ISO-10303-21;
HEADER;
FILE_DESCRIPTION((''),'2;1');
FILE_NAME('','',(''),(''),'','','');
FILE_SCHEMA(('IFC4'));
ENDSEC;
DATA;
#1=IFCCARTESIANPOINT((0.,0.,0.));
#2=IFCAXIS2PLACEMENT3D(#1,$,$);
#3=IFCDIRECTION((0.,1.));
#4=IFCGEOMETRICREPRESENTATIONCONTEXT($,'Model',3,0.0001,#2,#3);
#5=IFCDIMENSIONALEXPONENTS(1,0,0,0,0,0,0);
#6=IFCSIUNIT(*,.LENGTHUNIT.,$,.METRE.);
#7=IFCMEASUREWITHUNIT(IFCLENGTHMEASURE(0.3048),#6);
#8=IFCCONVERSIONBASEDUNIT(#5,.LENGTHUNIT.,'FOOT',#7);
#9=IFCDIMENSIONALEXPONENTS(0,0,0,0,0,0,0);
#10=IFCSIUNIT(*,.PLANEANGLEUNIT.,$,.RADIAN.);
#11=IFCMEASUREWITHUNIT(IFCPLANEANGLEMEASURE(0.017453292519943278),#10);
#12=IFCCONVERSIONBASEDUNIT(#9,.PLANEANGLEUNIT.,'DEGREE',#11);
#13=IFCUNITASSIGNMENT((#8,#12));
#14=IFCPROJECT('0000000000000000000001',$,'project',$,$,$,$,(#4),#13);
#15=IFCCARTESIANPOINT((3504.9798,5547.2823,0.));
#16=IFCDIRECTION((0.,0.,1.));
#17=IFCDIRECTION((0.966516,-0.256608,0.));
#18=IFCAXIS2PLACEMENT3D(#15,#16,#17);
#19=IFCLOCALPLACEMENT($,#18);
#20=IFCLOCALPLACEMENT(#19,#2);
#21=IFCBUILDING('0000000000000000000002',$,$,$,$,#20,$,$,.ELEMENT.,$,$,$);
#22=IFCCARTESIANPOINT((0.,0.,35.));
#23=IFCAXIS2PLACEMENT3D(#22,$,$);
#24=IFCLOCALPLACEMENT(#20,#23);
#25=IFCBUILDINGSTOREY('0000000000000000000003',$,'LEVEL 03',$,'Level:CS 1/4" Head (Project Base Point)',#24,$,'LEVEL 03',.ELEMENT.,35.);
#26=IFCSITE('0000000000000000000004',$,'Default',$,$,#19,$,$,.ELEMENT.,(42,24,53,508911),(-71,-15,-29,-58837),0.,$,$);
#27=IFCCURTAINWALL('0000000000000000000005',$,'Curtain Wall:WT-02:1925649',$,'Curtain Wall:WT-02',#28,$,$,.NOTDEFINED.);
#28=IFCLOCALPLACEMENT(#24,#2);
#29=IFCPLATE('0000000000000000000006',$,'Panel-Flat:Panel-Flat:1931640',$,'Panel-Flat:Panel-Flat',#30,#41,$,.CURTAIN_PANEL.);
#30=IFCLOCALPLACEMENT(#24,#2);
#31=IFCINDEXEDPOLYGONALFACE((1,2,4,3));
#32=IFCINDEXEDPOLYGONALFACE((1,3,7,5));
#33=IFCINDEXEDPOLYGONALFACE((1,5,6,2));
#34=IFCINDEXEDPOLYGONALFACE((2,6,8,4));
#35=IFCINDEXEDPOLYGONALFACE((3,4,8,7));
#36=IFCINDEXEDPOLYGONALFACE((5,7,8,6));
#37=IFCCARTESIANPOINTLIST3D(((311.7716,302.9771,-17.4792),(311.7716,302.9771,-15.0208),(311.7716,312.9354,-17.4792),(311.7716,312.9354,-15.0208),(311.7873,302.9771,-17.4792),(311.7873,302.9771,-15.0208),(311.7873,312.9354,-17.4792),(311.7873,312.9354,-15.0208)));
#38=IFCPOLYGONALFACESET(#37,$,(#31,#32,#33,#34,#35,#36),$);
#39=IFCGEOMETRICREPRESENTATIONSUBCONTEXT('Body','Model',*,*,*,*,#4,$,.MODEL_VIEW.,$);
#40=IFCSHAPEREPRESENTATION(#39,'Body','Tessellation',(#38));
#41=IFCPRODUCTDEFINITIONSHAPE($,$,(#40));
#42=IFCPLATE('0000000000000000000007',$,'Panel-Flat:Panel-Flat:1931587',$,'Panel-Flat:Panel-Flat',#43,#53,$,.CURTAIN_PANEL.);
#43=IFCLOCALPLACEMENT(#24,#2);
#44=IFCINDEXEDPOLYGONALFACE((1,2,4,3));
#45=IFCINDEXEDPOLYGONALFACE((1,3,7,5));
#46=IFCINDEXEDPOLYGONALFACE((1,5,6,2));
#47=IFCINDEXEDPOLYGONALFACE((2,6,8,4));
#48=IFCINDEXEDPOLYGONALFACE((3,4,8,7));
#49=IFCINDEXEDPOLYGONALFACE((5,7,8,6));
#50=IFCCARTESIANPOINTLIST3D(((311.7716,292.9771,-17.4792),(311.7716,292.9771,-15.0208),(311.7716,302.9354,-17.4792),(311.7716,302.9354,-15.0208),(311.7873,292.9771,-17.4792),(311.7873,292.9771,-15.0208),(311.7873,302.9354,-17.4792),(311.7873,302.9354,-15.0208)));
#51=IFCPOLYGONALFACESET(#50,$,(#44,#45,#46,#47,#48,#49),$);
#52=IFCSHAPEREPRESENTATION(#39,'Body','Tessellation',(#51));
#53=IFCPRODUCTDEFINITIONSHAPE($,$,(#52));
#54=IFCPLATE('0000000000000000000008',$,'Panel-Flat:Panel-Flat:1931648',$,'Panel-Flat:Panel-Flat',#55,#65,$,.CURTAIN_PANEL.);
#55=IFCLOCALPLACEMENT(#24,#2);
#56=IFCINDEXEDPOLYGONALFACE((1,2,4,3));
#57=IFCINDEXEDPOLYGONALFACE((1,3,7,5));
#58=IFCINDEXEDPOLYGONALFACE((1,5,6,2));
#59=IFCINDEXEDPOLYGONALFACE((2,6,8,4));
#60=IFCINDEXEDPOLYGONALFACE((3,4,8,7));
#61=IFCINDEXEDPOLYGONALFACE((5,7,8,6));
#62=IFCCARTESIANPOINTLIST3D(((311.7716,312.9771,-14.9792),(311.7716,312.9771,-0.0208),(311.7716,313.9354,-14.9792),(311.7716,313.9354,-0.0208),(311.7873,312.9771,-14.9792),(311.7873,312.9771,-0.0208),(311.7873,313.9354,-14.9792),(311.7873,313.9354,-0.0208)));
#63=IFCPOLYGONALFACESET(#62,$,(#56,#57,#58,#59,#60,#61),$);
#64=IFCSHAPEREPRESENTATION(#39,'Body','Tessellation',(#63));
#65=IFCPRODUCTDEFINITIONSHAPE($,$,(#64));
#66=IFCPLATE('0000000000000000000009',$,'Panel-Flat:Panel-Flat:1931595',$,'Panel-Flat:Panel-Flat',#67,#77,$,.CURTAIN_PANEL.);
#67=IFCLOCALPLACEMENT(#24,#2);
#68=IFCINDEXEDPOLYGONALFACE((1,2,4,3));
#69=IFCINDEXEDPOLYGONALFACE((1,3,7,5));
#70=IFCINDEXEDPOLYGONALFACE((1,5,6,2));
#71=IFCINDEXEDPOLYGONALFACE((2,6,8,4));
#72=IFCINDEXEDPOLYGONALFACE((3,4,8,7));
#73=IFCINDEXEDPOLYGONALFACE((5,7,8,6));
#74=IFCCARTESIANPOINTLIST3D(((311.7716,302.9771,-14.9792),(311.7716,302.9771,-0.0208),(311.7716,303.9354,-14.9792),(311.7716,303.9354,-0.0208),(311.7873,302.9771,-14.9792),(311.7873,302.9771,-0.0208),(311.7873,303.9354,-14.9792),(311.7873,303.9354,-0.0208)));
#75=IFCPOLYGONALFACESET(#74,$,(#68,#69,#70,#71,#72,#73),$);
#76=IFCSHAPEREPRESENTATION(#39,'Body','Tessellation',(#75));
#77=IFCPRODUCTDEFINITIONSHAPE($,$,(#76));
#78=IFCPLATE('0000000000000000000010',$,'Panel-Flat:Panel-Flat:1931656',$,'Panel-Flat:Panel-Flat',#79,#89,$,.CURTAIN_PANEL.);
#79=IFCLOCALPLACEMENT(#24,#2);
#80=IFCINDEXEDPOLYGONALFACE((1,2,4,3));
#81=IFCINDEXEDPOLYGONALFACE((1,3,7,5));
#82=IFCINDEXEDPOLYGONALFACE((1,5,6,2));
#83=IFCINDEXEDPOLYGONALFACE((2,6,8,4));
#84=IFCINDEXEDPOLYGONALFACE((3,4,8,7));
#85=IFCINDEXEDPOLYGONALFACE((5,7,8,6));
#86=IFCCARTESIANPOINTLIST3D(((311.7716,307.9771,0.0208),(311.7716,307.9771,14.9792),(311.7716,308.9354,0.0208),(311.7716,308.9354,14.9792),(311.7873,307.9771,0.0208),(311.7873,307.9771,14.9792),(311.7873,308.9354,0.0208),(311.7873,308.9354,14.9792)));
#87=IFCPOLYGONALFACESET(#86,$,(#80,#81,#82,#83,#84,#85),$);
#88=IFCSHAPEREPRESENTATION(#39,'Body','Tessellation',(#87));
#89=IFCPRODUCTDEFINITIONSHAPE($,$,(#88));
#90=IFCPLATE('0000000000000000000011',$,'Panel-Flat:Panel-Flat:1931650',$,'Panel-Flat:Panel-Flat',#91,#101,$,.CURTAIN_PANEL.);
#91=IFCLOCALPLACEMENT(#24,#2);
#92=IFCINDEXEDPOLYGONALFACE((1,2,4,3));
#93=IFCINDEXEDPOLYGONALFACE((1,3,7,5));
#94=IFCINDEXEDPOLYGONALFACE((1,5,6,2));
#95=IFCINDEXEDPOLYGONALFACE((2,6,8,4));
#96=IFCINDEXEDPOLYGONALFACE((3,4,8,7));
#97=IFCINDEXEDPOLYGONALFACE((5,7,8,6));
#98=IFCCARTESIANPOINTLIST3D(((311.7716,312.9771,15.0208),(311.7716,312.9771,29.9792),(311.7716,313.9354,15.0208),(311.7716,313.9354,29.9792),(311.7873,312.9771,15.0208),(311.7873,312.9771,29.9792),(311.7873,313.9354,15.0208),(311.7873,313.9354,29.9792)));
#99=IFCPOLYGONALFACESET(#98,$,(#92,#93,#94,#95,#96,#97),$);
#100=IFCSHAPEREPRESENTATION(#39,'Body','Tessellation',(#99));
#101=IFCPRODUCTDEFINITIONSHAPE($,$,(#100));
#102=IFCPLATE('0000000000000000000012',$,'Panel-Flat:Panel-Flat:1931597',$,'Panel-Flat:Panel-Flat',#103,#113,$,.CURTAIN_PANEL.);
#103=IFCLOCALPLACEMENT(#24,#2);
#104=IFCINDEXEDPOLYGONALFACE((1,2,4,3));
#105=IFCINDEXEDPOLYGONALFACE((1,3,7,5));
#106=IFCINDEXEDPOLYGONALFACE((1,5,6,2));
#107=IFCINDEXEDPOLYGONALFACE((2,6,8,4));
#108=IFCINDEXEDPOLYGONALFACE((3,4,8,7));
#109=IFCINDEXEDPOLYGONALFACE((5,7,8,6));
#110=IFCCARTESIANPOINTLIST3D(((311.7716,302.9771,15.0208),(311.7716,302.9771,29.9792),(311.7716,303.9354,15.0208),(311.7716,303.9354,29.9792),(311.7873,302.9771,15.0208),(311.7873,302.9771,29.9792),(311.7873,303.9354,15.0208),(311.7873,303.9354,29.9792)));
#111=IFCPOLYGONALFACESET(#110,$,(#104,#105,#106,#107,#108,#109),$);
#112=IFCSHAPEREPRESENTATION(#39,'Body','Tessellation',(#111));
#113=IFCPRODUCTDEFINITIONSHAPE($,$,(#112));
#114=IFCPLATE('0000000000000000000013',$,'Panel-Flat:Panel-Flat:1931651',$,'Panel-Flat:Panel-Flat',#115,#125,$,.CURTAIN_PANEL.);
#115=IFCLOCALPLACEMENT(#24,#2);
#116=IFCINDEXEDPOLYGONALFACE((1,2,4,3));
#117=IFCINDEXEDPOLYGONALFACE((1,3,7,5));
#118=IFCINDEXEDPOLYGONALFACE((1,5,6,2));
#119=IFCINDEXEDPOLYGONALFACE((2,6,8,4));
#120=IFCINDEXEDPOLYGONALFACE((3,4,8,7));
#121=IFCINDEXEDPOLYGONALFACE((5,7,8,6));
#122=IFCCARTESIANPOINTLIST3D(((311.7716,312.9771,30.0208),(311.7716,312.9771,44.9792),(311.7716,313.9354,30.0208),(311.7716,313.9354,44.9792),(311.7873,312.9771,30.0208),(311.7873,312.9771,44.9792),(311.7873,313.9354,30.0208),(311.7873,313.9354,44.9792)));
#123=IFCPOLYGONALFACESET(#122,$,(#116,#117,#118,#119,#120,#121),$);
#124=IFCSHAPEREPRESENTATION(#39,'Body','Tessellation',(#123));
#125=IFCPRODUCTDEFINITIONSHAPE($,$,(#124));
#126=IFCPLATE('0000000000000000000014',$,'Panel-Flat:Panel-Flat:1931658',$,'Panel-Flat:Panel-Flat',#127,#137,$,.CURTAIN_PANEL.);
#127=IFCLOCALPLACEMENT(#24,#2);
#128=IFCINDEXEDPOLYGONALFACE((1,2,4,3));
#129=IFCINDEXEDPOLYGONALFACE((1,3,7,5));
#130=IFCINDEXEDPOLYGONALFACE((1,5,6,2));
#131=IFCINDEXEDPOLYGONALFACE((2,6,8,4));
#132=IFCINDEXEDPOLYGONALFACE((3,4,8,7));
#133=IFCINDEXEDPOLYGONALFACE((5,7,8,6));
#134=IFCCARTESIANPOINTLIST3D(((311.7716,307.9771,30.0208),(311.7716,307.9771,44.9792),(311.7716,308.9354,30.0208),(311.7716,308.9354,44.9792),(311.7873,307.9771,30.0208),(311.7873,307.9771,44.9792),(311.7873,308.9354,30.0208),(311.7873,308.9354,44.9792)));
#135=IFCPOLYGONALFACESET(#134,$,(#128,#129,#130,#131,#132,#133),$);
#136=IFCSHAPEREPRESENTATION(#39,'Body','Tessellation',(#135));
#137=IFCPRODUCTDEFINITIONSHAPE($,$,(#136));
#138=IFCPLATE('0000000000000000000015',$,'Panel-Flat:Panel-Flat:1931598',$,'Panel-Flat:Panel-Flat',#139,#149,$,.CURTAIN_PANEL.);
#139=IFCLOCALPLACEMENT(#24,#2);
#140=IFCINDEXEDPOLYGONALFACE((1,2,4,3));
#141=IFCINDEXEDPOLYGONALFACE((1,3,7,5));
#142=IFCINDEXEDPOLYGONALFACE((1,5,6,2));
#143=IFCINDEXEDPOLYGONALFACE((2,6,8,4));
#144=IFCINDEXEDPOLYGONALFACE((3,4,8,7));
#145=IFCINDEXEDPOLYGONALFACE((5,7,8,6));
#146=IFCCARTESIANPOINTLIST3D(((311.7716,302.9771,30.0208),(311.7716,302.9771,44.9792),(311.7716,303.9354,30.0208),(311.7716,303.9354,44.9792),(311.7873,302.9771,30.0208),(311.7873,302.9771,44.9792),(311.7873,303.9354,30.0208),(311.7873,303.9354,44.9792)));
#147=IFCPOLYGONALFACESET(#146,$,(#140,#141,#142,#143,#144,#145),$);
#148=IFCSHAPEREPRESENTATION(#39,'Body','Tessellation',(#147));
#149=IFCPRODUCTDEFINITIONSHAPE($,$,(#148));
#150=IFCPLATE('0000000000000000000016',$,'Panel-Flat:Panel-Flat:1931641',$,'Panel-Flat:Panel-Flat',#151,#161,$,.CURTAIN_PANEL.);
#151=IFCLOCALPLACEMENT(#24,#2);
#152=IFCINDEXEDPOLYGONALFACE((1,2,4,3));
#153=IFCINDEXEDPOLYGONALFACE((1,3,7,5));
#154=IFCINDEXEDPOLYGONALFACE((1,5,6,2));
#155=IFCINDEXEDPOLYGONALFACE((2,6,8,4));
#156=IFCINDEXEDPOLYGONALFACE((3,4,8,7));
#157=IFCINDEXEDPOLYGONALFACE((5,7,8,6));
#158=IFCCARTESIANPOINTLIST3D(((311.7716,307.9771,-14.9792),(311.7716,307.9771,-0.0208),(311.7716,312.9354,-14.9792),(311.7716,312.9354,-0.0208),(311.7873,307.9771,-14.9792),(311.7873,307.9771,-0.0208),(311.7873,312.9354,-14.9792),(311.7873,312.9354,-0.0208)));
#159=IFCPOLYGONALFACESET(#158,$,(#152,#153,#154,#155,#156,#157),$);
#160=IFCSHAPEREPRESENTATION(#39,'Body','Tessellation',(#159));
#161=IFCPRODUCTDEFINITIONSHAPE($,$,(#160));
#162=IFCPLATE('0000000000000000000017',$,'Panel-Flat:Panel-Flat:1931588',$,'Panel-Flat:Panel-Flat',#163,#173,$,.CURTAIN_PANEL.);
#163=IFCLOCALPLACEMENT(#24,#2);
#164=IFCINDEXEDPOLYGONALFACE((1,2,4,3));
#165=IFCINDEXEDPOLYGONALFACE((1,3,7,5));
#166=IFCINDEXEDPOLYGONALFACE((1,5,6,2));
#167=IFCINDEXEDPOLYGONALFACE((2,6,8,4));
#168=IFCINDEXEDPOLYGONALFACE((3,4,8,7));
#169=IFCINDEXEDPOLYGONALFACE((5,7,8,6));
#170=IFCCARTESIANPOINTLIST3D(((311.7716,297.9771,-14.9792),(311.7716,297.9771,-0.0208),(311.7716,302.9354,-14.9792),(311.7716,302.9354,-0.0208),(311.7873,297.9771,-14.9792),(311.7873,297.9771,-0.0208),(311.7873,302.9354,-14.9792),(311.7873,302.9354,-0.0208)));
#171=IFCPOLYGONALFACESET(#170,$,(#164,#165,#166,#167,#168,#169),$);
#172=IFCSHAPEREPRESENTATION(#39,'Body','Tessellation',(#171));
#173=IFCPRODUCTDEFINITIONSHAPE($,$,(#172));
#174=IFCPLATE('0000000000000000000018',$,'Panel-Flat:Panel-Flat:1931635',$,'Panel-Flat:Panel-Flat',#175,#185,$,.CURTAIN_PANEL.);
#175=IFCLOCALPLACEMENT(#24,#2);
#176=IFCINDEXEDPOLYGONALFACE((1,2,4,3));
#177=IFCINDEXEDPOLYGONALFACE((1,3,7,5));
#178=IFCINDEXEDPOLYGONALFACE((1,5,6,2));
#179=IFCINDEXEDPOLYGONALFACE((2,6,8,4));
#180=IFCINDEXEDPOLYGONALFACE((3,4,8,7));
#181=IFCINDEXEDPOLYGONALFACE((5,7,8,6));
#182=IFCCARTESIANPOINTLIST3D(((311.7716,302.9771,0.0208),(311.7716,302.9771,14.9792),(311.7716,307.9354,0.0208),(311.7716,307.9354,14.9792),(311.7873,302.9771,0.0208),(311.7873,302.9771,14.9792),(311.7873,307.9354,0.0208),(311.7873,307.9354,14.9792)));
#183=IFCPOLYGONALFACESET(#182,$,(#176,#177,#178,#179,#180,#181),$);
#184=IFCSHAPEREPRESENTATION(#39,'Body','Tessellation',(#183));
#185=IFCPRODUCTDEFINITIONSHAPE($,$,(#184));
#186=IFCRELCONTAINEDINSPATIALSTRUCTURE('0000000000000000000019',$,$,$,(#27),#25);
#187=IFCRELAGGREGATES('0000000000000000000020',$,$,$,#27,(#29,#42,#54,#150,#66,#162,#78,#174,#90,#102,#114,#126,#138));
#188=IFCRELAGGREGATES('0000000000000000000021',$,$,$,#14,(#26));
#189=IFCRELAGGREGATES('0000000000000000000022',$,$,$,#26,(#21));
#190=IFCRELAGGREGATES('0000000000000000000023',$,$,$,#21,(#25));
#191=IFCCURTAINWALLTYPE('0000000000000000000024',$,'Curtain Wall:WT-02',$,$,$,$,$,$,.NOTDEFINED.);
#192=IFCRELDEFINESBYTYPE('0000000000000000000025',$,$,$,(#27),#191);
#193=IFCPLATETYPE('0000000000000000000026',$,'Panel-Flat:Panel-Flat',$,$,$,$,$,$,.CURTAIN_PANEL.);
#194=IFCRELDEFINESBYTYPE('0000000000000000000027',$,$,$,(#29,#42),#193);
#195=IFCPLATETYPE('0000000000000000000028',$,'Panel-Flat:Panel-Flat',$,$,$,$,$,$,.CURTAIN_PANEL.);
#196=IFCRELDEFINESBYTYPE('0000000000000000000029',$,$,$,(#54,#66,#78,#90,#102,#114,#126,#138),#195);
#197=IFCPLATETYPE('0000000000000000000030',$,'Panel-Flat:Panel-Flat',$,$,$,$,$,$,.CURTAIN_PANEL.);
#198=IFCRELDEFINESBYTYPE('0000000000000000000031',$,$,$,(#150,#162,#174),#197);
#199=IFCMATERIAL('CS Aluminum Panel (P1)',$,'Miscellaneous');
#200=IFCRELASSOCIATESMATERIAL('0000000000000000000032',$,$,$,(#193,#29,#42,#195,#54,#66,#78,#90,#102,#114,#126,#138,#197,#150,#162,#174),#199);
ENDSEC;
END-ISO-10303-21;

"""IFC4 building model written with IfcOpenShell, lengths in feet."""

from ifc_helpers import new_model, entity, si_unit, converted_unit, direction, frame, origin, place, context, subcontext, project, spatial, indexed_curve, outline, extrude, source, transform, mapped, material, type_object, type_shapes, element, aggregate, save


model = new_model("IFC4")

# Units and contexts
model_context = context("Model", 3, precision=0.0001, world=origin(), true_north=direction((0.0, 1.0)))
body_context = subcontext(model_context, "Body", "Model", "MODEL_VIEW")
ifc_project = project(units=[converted_unit("LENGTHUNIT", "FOOT", entity("IfcLengthMeasure", 0.3048), si_unit("LENGTHUNIT", "METRE"), dimensions=[1, 0, 0, 0, 0, 0, 0]), converted_unit("PLANEANGLEUNIT", "DEGREE", entity("IfcPlaneAngleMeasure", 0.017453292519943278), si_unit("PLANEANGLEUNIT", "RADIAN"), dimensions=[0, 0, 0, 0, 0, 0, 0])], contexts=[model_context])

# Site, building, storey
site_placement = place(None, frame((3504.9798, 5547.2823, 0.0), z_axis=(0.0, 0.0, 1.0), x_axis=(0.966516, -0.256608, 0.0)))
site = spatial("IfcSite", under=ifc_project, at=site_placement, Name="Default", CompositionType="ELEMENT", RefLatitude=(42, 24, 53, 508911), RefLongitude=(-71, -15, -29, -58837), RefElevation=0.0)
building_placement = place(site_placement, origin())
building = spatial("IfcBuilding", under=site, at=building_placement, CompositionType="ELEMENT")
storey_placement = place(building_placement, frame((0.0, 0.0, 35.0)))
storey = spatial("IfcBuildingStorey", under=building, at=storey_placement, Name="LEVEL 03", ObjectType="Level:CS 1/4\" Head (Project Base Point)", LongName="LEVEL 03", CompositionType="ELEMENT", Elevation=35.0)

# Curtain wall, plates
curtain_wall_type = type_object("IfcCurtainWallType", Name="Curtain Wall:WT-02", PredefinedType="NOTDEFINED")
curtain_wall_1_placement = place(storey_placement, frame((0.0, 0.0, -35.0)))
curtain_wall_1 = element("IfcCurtainWall", 1, at=curtain_wall_1_placement, inside=storey, type_object=curtain_wall_type, Name="Curtain Wall:WT-02:1925649", ObjectType="Curtain Wall:WT-02", PredefinedType="NOTDEFINED")
ifc_material_1 = material(Name="CS Aluminum Panel (P1)", Category="Miscellaneous")
plate_type_1 = type_object("IfcPlateType", Name="Panel-Flat:Panel-Flat", PredefinedType="CURTAIN_PANEL", material=ifc_material_1)
shared_shape_1 = source(origin(), body_context, "Body", "SweptSolid", [
    extrude(outline(indexed_curve([(-0.0078, -4.9792), (0.0078, -4.9792), (0.0078, 4.9792), (-0.0078, 4.9792), (-0.0078, -4.9792)], self_intersect=False)), frame((4.9792, 0.0078, 0.0), z_axis=(0.0, 0.0, 1.0), x_axis=(0.0, -1.0, 0.0)), (0.0, 0.0, 1.0), 2.4583),
])
type_shapes(plate_type_1, [shared_shape_1])
plate_1_placement = place(curtain_wall_1_placement, frame((311.7716, 312.9354, 17.5208), z_axis=(0.0, 0.0, 1.0), x_axis=(0.0, -1.0, 0.0)))
plate_1 = element("IfcPlate", 2, at=plate_1_placement, type_object=plate_type_1, material=ifc_material_1, Name="Panel-Flat:Panel-Flat:1931640", ObjectType="Panel-Flat:Panel-Flat", PredefinedType="CURTAIN_PANEL", context=body_context, shape_type="MappedRepresentation", body=[
    mapped(shared_shape_1, transform((0.0, 0.0, 0.0), scale=1.0)),
])
plate_2_placement = place(curtain_wall_1_placement, frame((311.7716, 302.9354, 17.5208), z_axis=(0.0, 0.0, 1.0), x_axis=(0.0, -1.0, 0.0)))
plate_2 = element("IfcPlate", 3, at=plate_2_placement, type_object=plate_type_1, material=ifc_material_1, Name="Panel-Flat:Panel-Flat:1931587", ObjectType="Panel-Flat:Panel-Flat", PredefinedType="CURTAIN_PANEL", context=body_context, shape_type="MappedRepresentation", body=[
    mapped(shared_shape_1, transform((0.0, 0.0, 0.0), scale=1.0)),
])
plate_type_2 = type_object("IfcPlateType", Name="Panel-Flat:Panel-Flat", PredefinedType="CURTAIN_PANEL", material=ifc_material_1)
shared_shape_2 = source(origin(), body_context, "Body", "SweptSolid", [
    extrude(outline(indexed_curve([(-0.0078, -0.4792), (0.0078, -0.4792), (0.0078, 0.4792), (-0.0078, 0.4792), (-0.0078, -0.4792)], self_intersect=False)), frame((0.4792, 0.0078, 0.0), z_axis=(0.0, 0.0, 1.0), x_axis=(0.0, -1.0, 0.0)), (0.0, 0.0, 1.0), 14.9583),
])
type_shapes(plate_type_2, [shared_shape_2])
plate_3_placement = place(curtain_wall_1_placement, frame((311.7716, 313.9354, 20.0208), z_axis=(0.0, 0.0, 1.0), x_axis=(0.0, -1.0, 0.0)))
plate_3 = element("IfcPlate", 4, at=plate_3_placement, type_object=plate_type_2, material=ifc_material_1, Name="Panel-Flat:Panel-Flat:1931648", ObjectType="Panel-Flat:Panel-Flat", PredefinedType="CURTAIN_PANEL", context=body_context, shape_type="MappedRepresentation", body=[
    mapped(shared_shape_2, transform((0.0, 0.0, 0.0), scale=1.0)),
])
plate_4_placement = place(curtain_wall_1_placement, frame((311.7716, 303.9354, 20.0208), z_axis=(0.0, 0.0, 1.0), x_axis=(0.0, -1.0, 0.0)))
plate_4 = element("IfcPlate", 5, at=plate_4_placement, type_object=plate_type_2, material=ifc_material_1, Name="Panel-Flat:Panel-Flat:1931595", ObjectType="Panel-Flat:Panel-Flat", PredefinedType="CURTAIN_PANEL", context=body_context, shape_type="MappedRepresentation", body=[
    mapped(shared_shape_2, transform((0.0, 0.0, 0.0), scale=1.0)),
])
plate_5_placement = place(curtain_wall_1_placement, frame((311.7716, 308.9354, 35.0208), z_axis=(0.0, 0.0, 1.0), x_axis=(0.0, -1.0, 0.0)))
plate_5 = element("IfcPlate", 6, at=plate_5_placement, type_object=plate_type_2, material=ifc_material_1, Name="Panel-Flat:Panel-Flat:1931656", ObjectType="Panel-Flat:Panel-Flat", PredefinedType="CURTAIN_PANEL", context=body_context, shape_type="MappedRepresentation", body=[
    mapped(shared_shape_2, transform((0.0, 0.0, 0.0), scale=1.0)),
])
plate_6_placement = place(curtain_wall_1_placement, frame((311.7716, 313.9354, 50.0208), z_axis=(0.0, 0.0, 1.0), x_axis=(0.0, -1.0, 0.0)))
plate_6 = element("IfcPlate", 7, at=plate_6_placement, type_object=plate_type_2, material=ifc_material_1, Name="Panel-Flat:Panel-Flat:1931650", ObjectType="Panel-Flat:Panel-Flat", PredefinedType="CURTAIN_PANEL", context=body_context, shape_type="MappedRepresentation", body=[
    mapped(shared_shape_2, transform((0.0, 0.0, 0.0), scale=1.0)),
])
plate_7_placement = place(curtain_wall_1_placement, frame((311.7716, 303.9354, 50.0208), z_axis=(0.0, 0.0, 1.0), x_axis=(0.0, -1.0, 0.0)))
plate_7 = element("IfcPlate", 8, at=plate_7_placement, type_object=plate_type_2, material=ifc_material_1, Name="Panel-Flat:Panel-Flat:1931597", ObjectType="Panel-Flat:Panel-Flat", PredefinedType="CURTAIN_PANEL", context=body_context, shape_type="MappedRepresentation", body=[
    mapped(shared_shape_2, transform((0.0, 0.0, 0.0), scale=1.0)),
])
plate_8_placement = place(curtain_wall_1_placement, frame((311.7716, 313.9354, 65.0208), z_axis=(0.0, 0.0, 1.0), x_axis=(0.0, -1.0, 0.0)))
plate_8 = element("IfcPlate", 9, at=plate_8_placement, type_object=plate_type_2, material=ifc_material_1, Name="Panel-Flat:Panel-Flat:1931651", ObjectType="Panel-Flat:Panel-Flat", PredefinedType="CURTAIN_PANEL", context=body_context, shape_type="MappedRepresentation", body=[
    mapped(shared_shape_2, transform((0.0, 0.0, 0.0), scale=1.0)),
])
plate_9_placement = place(curtain_wall_1_placement, frame((311.7716, 308.9354, 65.0208), z_axis=(0.0, 0.0, 1.0), x_axis=(0.0, -1.0, 0.0)))
plate_9 = element("IfcPlate", 10, at=plate_9_placement, type_object=plate_type_2, material=ifc_material_1, Name="Panel-Flat:Panel-Flat:1931658", ObjectType="Panel-Flat:Panel-Flat", PredefinedType="CURTAIN_PANEL", context=body_context, shape_type="MappedRepresentation", body=[
    mapped(shared_shape_2, transform((0.0, 0.0, 0.0), scale=1.0)),
])
plate_10_placement = place(curtain_wall_1_placement, frame((311.7716, 303.9354, 65.0208), z_axis=(0.0, 0.0, 1.0), x_axis=(0.0, -1.0, 0.0)))
plate_10 = element("IfcPlate", 11, at=plate_10_placement, type_object=plate_type_2, material=ifc_material_1, Name="Panel-Flat:Panel-Flat:1931598", ObjectType="Panel-Flat:Panel-Flat", PredefinedType="CURTAIN_PANEL", context=body_context, shape_type="MappedRepresentation", body=[
    mapped(shared_shape_2, transform((0.0, 0.0, 0.0), scale=1.0)),
])
plate_type_3 = type_object("IfcPlateType", Name="Panel-Flat:Panel-Flat", PredefinedType="CURTAIN_PANEL", material=ifc_material_1)
shared_shape_3 = source(origin(), body_context, "Body", "SweptSolid", [
    extrude(outline(indexed_curve([(-0.0078, -2.4792), (0.0078, -2.4792), (0.0078, 2.4792), (-0.0078, 2.4792), (-0.0078, -2.4792)], self_intersect=False)), frame((2.4792, 0.0078, 0.0), z_axis=(0.0, 0.0, 1.0), x_axis=(0.0, -1.0, 0.0)), (0.0, 0.0, 1.0), 14.9583),
])
type_shapes(plate_type_3, [shared_shape_3])
plate_11_placement = place(curtain_wall_1_placement, frame((311.7716, 312.9354, 20.0208), z_axis=(0.0, 0.0, 1.0), x_axis=(0.0, -1.0, 0.0)))
plate_11 = element("IfcPlate", 12, at=plate_11_placement, type_object=plate_type_3, material=ifc_material_1, Name="Panel-Flat:Panel-Flat:1931641", ObjectType="Panel-Flat:Panel-Flat", PredefinedType="CURTAIN_PANEL", context=body_context, shape_type="MappedRepresentation", body=[
    mapped(shared_shape_3, transform((0.0, 0.0, 0.0), scale=1.0)),
])
plate_12_placement = place(curtain_wall_1_placement, frame((311.7716, 302.9354, 20.0208), z_axis=(0.0, 0.0, 1.0), x_axis=(0.0, -1.0, 0.0)))
plate_12 = element("IfcPlate", 13, at=plate_12_placement, type_object=plate_type_3, material=ifc_material_1, Name="Panel-Flat:Panel-Flat:1931588", ObjectType="Panel-Flat:Panel-Flat", PredefinedType="CURTAIN_PANEL", context=body_context, shape_type="MappedRepresentation", body=[
    mapped(shared_shape_3, transform((0.0, 0.0, 0.0), scale=1.0)),
])
plate_13_placement = place(curtain_wall_1_placement, frame((311.7716, 307.9354, 35.0208), z_axis=(0.0, 0.0, 1.0), x_axis=(0.0, -1.0, 0.0)))
plate_13 = element("IfcPlate", 14, at=plate_13_placement, type_object=plate_type_3, material=ifc_material_1, Name="Panel-Flat:Panel-Flat:1931635", ObjectType="Panel-Flat:Panel-Flat", PredefinedType="CURTAIN_PANEL", context=body_context, shape_type="MappedRepresentation", body=[
    mapped(shared_shape_3, transform((0.0, 0.0, 0.0), scale=1.0)),
])

aggregate(curtain_wall_1, [plate_1, plate_2, plate_3, plate_11, plate_4, plate_12, plate_5, plate_13, plate_6, plate_7, plate_8, plate_9, plate_10])

save(model, "model.ifc")
